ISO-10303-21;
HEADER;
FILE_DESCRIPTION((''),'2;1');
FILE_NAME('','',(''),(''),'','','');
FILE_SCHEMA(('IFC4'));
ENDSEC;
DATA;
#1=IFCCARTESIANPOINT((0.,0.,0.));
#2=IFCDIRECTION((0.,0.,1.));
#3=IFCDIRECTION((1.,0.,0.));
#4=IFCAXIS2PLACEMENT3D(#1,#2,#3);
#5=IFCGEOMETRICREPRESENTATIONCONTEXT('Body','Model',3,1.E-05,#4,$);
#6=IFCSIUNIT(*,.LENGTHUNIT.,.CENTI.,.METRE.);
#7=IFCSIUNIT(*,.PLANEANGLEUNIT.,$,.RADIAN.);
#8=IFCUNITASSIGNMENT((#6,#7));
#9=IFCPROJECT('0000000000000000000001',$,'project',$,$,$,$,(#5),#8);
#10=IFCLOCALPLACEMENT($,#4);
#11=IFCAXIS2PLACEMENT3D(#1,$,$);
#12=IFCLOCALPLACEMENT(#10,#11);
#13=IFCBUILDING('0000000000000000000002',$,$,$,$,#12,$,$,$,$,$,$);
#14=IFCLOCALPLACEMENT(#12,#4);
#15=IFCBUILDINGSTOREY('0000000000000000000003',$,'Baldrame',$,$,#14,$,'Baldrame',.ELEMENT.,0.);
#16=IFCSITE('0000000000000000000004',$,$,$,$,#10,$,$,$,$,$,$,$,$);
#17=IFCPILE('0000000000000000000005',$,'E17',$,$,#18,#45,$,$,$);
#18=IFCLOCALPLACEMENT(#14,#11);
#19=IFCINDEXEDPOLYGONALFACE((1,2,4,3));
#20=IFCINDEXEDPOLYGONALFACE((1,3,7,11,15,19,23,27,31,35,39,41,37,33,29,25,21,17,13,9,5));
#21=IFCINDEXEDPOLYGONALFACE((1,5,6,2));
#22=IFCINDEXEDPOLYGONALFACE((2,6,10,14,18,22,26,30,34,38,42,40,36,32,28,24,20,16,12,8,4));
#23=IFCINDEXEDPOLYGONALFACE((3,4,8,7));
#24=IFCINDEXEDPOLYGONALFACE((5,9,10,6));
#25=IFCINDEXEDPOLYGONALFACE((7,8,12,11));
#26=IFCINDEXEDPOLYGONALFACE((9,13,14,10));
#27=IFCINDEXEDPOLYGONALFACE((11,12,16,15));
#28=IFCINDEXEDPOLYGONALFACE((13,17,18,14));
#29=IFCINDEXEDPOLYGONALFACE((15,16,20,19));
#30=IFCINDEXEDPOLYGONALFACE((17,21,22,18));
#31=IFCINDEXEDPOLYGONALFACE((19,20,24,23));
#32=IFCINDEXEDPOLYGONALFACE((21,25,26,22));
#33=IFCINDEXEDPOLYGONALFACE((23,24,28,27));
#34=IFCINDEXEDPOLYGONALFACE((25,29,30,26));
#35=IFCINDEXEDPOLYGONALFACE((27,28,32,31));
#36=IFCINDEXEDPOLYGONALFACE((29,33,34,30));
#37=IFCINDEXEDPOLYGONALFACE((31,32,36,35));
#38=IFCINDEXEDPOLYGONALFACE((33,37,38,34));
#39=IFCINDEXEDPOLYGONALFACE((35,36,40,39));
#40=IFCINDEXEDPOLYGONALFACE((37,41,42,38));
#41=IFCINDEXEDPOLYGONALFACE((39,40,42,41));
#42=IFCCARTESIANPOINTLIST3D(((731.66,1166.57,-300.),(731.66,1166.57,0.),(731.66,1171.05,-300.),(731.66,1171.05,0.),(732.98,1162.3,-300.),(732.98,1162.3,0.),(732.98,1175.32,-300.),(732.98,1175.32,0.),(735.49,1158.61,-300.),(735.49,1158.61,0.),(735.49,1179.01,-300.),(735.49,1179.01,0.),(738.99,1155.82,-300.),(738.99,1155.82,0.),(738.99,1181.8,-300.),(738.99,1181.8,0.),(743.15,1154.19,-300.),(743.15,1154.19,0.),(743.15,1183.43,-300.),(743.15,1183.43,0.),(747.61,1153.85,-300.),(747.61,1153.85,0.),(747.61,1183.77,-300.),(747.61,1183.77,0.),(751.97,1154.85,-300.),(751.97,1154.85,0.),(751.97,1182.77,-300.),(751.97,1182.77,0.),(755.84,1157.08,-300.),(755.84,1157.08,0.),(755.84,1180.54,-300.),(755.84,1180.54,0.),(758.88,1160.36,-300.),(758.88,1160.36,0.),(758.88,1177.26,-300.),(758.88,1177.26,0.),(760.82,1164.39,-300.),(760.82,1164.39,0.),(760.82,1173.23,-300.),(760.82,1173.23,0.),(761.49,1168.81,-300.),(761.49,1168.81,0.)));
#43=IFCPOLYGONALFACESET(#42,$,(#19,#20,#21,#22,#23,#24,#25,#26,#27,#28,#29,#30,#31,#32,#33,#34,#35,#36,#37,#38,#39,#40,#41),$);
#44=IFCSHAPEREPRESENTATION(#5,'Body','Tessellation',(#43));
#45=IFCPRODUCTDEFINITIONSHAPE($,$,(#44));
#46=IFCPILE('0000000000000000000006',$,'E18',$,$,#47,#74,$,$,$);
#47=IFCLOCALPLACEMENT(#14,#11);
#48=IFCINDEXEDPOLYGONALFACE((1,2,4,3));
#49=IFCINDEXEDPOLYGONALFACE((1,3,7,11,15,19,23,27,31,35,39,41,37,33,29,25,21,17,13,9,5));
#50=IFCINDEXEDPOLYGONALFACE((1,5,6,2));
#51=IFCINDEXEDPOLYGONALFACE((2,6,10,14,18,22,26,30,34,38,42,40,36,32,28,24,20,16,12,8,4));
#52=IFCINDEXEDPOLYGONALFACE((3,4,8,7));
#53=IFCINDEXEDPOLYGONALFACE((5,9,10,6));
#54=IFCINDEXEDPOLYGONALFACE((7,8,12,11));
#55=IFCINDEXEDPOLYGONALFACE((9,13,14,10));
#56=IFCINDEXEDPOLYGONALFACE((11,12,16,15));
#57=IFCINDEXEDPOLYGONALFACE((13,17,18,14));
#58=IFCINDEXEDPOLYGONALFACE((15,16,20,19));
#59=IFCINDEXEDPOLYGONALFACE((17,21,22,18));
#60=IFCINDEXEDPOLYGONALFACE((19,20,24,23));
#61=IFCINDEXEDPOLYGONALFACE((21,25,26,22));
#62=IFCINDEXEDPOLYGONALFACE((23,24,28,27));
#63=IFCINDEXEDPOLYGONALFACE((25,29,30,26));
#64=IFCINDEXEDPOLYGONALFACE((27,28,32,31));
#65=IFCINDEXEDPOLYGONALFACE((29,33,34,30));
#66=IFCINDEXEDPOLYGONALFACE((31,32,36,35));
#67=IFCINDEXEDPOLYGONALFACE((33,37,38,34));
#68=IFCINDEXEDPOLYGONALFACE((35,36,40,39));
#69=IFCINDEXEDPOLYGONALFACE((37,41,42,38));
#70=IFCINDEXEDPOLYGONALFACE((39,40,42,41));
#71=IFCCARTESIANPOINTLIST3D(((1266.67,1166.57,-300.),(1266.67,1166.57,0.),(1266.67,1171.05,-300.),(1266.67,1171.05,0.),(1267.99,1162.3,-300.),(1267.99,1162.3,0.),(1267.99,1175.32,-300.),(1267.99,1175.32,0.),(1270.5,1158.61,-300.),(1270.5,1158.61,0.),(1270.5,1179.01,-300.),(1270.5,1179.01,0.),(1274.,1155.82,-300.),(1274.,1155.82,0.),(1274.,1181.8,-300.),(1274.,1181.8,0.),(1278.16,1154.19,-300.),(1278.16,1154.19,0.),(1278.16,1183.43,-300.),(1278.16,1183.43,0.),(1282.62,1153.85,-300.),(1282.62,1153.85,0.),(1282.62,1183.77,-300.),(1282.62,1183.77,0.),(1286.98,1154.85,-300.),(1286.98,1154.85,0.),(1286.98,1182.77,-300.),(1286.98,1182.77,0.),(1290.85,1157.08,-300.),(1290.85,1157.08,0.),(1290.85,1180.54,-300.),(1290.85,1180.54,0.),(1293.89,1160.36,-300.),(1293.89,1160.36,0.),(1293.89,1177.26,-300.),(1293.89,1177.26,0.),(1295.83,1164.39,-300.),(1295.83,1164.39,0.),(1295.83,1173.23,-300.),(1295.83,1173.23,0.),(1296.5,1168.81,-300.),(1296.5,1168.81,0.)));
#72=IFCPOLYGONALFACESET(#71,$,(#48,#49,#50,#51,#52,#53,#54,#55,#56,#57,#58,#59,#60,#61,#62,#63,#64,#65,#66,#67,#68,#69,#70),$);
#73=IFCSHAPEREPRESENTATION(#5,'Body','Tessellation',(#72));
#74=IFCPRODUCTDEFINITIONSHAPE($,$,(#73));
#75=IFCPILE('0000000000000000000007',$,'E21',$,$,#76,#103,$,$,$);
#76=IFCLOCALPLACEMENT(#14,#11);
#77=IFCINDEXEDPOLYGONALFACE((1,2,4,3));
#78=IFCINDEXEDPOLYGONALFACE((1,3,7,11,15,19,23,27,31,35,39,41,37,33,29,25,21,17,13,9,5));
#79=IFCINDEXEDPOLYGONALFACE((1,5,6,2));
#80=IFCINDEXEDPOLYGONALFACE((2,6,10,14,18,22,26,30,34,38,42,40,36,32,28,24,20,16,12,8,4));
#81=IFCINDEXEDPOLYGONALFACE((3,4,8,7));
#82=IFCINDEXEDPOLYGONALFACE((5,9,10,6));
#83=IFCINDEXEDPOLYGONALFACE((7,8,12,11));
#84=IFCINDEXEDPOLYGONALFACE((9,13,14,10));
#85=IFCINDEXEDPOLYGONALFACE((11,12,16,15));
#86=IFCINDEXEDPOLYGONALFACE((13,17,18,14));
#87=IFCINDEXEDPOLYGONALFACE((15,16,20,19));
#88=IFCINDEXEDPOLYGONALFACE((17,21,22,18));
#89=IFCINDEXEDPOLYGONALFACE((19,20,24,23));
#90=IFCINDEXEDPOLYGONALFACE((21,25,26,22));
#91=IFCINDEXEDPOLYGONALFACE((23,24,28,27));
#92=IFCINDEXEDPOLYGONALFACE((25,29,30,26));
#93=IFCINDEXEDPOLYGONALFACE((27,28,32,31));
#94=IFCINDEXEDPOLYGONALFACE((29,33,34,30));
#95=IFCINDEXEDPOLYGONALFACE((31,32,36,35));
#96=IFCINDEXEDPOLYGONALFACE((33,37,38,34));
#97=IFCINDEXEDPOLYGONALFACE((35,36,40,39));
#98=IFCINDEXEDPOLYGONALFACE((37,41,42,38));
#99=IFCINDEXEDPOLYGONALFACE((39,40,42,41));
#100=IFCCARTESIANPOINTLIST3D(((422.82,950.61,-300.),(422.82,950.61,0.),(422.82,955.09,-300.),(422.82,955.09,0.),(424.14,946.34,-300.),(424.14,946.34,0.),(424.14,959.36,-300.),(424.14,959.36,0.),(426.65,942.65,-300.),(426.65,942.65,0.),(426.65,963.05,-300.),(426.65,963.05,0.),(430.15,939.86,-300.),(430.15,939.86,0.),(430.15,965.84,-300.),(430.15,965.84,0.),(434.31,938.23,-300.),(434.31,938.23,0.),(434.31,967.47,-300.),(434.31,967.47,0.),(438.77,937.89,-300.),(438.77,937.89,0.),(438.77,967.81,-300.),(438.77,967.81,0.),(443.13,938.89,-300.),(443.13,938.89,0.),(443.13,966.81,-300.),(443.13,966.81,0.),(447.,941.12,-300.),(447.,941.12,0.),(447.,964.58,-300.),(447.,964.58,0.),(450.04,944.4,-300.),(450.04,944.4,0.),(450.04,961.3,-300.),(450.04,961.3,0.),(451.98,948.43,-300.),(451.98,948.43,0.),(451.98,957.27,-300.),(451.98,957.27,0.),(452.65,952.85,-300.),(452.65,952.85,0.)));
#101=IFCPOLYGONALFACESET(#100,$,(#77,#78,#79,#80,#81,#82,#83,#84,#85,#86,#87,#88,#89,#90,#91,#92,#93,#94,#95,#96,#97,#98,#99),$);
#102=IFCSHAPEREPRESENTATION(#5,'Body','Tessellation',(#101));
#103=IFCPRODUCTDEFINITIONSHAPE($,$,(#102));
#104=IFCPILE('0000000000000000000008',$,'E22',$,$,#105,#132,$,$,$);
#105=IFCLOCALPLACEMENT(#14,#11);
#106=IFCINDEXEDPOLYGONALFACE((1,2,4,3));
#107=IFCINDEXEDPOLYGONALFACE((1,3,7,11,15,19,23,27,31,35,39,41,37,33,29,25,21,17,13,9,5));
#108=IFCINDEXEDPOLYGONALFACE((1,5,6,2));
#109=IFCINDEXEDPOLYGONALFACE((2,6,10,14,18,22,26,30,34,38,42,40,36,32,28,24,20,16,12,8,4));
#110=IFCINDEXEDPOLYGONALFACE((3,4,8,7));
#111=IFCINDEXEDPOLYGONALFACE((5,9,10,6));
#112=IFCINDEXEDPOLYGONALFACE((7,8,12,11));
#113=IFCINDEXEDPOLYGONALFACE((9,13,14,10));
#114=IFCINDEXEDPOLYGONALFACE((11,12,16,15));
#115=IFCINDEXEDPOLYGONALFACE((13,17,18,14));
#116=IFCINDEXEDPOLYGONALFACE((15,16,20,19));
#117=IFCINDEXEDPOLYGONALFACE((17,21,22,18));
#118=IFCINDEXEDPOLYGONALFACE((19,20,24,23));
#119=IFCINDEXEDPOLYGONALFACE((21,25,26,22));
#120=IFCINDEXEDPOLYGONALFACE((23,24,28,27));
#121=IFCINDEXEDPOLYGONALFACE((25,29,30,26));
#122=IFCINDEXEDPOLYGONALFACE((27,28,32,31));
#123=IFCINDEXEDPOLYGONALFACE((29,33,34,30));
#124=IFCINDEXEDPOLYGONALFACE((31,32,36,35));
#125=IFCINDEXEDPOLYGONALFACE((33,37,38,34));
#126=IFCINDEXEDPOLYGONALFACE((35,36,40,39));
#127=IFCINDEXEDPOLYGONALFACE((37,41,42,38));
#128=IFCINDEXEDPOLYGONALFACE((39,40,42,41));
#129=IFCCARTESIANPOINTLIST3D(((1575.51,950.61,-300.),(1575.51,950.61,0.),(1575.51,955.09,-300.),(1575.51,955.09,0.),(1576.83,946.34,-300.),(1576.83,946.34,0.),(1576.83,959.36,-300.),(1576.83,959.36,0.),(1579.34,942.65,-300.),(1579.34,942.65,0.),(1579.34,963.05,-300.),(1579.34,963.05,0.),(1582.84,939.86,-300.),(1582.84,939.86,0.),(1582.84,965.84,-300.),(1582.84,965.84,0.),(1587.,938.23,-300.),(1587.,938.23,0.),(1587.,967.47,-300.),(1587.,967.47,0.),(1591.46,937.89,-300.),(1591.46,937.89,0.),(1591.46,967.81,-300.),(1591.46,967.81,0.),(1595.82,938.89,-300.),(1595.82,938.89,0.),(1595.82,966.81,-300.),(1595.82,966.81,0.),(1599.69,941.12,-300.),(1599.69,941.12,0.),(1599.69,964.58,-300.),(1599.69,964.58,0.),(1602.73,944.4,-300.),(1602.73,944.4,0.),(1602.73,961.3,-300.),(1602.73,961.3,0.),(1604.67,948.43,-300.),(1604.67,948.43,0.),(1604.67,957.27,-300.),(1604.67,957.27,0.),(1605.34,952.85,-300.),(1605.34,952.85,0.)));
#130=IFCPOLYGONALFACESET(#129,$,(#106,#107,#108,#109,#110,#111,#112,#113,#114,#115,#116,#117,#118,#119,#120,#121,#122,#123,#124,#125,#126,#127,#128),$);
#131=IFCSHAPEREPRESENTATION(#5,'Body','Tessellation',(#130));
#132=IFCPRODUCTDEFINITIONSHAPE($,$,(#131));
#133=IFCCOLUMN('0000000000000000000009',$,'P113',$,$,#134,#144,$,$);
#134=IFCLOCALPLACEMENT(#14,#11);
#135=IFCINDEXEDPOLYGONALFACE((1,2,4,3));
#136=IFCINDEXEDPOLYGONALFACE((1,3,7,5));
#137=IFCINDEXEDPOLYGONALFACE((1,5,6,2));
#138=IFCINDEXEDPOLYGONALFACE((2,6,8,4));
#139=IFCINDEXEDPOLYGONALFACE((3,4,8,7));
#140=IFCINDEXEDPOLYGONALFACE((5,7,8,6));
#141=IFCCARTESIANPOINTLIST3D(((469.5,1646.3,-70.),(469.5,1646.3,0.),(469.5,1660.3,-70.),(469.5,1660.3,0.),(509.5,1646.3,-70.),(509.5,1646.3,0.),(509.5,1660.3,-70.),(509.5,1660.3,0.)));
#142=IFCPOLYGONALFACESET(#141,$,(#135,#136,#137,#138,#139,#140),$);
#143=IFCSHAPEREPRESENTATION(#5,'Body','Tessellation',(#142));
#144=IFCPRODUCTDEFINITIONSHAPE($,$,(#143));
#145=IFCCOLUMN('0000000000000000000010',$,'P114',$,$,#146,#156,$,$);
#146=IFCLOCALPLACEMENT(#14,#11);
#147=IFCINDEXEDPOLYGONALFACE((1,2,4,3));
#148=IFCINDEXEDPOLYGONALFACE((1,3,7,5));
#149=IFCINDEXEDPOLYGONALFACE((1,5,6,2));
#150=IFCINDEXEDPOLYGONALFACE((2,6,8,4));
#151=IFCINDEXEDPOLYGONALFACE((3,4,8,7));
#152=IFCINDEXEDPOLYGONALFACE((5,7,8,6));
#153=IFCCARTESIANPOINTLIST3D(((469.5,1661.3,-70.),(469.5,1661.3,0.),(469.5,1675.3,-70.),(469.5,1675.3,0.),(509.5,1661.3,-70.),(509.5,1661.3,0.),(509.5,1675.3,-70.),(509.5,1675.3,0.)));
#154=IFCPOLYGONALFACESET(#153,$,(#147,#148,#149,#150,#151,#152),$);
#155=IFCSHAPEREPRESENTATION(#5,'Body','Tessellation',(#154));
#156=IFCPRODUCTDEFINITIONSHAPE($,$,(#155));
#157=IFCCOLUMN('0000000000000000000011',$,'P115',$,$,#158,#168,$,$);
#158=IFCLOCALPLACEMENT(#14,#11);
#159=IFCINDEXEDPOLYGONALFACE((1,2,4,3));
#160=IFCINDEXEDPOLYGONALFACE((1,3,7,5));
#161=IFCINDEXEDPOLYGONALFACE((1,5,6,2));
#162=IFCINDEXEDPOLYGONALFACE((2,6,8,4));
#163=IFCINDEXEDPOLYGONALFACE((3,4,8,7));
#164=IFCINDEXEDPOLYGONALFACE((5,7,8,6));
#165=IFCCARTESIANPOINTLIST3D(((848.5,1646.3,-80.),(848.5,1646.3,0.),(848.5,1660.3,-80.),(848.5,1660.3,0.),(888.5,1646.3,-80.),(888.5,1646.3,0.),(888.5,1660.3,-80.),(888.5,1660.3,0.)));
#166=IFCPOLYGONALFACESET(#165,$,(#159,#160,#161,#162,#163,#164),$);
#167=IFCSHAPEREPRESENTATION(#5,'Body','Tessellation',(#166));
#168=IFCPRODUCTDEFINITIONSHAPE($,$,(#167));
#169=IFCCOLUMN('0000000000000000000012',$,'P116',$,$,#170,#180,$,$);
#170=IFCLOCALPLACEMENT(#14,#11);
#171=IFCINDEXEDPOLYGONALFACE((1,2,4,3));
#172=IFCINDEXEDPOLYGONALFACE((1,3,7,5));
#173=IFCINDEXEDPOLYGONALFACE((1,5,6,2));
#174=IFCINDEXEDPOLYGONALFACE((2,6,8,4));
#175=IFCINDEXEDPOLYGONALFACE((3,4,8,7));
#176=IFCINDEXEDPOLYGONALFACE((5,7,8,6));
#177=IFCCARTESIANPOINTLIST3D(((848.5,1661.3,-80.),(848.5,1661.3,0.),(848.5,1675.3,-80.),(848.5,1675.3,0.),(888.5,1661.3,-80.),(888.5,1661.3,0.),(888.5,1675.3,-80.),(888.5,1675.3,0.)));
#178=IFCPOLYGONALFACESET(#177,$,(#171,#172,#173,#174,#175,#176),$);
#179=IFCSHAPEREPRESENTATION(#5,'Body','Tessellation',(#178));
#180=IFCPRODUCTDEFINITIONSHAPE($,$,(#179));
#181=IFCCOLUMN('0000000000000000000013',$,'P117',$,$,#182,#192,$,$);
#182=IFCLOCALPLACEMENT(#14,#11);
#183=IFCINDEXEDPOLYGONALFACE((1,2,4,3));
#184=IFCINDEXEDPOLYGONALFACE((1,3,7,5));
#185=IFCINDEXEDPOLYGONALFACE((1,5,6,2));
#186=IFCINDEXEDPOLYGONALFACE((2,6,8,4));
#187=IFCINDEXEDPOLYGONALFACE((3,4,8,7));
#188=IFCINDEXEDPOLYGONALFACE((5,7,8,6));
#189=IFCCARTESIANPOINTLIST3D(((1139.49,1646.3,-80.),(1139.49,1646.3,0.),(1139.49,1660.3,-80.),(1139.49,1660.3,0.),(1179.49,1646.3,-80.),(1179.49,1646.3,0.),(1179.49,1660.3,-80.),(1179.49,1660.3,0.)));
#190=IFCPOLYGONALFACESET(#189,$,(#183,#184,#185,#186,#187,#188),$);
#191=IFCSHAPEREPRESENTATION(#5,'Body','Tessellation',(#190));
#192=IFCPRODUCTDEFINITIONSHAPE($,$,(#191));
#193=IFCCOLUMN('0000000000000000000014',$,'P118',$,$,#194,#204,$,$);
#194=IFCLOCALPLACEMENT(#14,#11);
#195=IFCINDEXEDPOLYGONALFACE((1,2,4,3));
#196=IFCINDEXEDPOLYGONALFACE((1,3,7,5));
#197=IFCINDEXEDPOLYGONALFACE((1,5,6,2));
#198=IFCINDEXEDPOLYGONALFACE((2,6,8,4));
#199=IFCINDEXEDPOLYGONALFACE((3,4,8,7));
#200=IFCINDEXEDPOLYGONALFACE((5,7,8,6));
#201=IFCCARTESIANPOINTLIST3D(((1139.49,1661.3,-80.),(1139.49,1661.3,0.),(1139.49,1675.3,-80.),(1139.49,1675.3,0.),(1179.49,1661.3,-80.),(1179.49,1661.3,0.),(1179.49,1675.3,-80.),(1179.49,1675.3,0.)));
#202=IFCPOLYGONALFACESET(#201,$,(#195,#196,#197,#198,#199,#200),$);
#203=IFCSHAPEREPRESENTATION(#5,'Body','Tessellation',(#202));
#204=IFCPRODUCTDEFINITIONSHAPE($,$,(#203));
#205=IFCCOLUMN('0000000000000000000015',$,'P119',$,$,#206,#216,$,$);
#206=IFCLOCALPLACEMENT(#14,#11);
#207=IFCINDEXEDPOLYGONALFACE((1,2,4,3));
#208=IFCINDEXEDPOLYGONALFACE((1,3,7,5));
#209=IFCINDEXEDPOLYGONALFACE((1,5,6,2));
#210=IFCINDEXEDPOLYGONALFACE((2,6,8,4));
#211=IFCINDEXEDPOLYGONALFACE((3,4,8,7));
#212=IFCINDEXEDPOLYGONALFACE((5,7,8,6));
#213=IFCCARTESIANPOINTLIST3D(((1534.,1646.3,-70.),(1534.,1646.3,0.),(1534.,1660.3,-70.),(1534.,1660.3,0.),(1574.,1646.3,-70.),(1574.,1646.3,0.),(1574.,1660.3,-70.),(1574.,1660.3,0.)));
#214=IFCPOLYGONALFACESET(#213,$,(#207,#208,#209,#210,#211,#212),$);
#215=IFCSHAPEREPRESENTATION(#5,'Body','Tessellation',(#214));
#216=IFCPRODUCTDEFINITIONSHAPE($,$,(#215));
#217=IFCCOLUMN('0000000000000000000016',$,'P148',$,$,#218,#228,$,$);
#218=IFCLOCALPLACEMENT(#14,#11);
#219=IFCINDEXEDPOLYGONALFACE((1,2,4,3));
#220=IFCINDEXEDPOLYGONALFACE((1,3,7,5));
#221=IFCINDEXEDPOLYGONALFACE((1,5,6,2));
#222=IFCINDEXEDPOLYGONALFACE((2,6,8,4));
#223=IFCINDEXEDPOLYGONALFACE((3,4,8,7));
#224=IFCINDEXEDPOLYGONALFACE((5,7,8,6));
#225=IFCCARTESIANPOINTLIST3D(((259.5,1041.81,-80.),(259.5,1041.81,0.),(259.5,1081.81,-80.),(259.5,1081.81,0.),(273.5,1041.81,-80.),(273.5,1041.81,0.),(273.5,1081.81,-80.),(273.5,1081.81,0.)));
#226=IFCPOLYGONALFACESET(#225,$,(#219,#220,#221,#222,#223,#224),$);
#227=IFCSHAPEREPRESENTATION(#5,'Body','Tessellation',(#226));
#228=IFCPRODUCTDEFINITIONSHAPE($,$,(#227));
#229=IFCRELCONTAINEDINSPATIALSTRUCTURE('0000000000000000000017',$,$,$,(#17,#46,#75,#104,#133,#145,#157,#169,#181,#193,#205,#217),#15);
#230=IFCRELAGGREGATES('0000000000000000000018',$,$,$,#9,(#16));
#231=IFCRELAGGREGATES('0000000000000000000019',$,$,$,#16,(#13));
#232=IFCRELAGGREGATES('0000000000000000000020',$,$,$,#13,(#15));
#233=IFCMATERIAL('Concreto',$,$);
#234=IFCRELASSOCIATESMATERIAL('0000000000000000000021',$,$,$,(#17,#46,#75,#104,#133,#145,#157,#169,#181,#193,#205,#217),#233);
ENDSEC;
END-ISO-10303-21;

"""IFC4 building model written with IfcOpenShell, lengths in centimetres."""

from ifc_helpers import new_model, si_unit, frame, origin, origin_with_axes, origin_2d_with_axis, place, context, project, spatial, rectangle, circle, extrude, material, element, save


model = new_model("IFC4")

# Units and contexts
model_context = context("Model", 3, precision=1e-05, world=origin_with_axes(), identifier="Body")
ifc_project = project(units=[si_unit("LENGTHUNIT", "METRE", prefix="CENTI"), si_unit("PLANEANGLEUNIT", "RADIAN")], contexts=[model_context])

# Site, building, storey
site_placement = place(None, origin_with_axes())
site = spatial("IfcSite", under=ifc_project, at=site_placement)
building_placement = place(site_placement, origin())
building = spatial("IfcBuilding", under=site, at=building_placement)
storey_placement = place(building_placement, origin_with_axes())
storey = spatial("IfcBuildingStorey", under=building, at=storey_placement, Name="Baldrame", LongName="Baldrame", CompositionType="ELEMENT", Elevation=0.0)

# Piles
ifc_material = material(Name="Concreto")
for number, where, z_axis, x_axis, name in (
    (1, (746.49, 1168.81, 0.0), (0.0, 0.0, 1.0), (1.0, 0.0, 0.0), "E17"),
    (2, (1281.5, 1168.81, 0.0), (0.0, 0.0, 1.0), (1.0, 0.0, 0.0), "E18"),
    (3, (437.65, 952.85, 0.0), (0.0, 0.0, 1.0), (1.0, 0.0, 0.0), "E21"),
    (4, (1590.34, 952.85, 0.0), (0.0, 0.0, 1.0), (1.0, 0.0, 0.0), "E22"),
):
    element("IfcPile", number, at=place(storey_placement, frame(where, z_axis=z_axis, x_axis=x_axis)), inside=storey, material=ifc_material, Name=name, context=model_context, shape_type="SolidModel", body=[
        extrude(circle(Radius=15.0, at=origin_2d_with_axis()), frame((0.0, 0.0, -300.0), z_axis=(0.0, 0.0, 1.0), x_axis=(1.0, 0.0, 0.0)), (0.0, 0.0, 1.0), 300.0),
    ])

# Columns
for number, where, z_axis, x_axis, name in (
    (5, (489.5, 1653.3, 0.0), (0.0, 0.0, 1.0), (1.0, 0.0, 0.0), "P113"),
    (6, (489.5, 1668.3, 0.0), (0.0, 0.0, 1.0), (1.0, 0.0, 0.0), "P114"),
):
    element("IfcColumn", number, at=place(storey_placement, frame(where, z_axis=z_axis, x_axis=x_axis)), inside=storey, material=ifc_material, Name=name, context=model_context, shape_type="SolidModel", body=[
        extrude(rectangle(XDim=14.0, YDim=40.0, at=origin_2d_with_axis()), frame((0.0, 0.0, -70.0), z_axis=(0.0, 0.0, 1.0), x_axis=(0.0, 1.0, 0.0)), (0.0, 0.0, 1.0), 70.0),
    ])
for number, where, z_axis, x_axis, name in (
    (7, (868.5, 1653.3, 0.0), (0.0, 0.0, 1.0), (1.0, 0.0, 0.0), "P115"),
    (8, (868.5, 1668.3, 0.0), (0.0, 0.0, 1.0), (1.0, 0.0, 0.0), "P116"),
    (9, (1159.49, 1653.3, 0.0), (0.0, 0.0, 1.0), (1.0, 0.0, 0.0), "P117"),
    (10, (1159.49, 1668.3, 0.0), (0.0, 0.0, 1.0), (1.0, 0.0, 0.0), "P118"),
):
    element("IfcColumn", number, at=place(storey_placement, frame(where, z_axis=z_axis, x_axis=x_axis)), inside=storey, material=ifc_material, Name=name, context=model_context, shape_type="SolidModel", body=[
        extrude(rectangle(XDim=14.0, YDim=40.0, at=origin_2d_with_axis()), frame((0.0, 0.0, -80.0), z_axis=(0.0, 0.0, 1.0), x_axis=(0.0, -1.0, 0.0)), (0.0, 0.0, 1.0), 80.0),
    ])
column_1_placement = place(storey_placement, frame((1554.0, 1653.3, 0.0), z_axis=(0.0, 0.0, 1.0), x_axis=(1.0, 0.0, 0.0)))
element("IfcColumn", 11, at=column_1_placement, inside=storey, material=ifc_material, Name="P119", context=model_context, shape_type="SolidModel", body=[
    extrude(rectangle(XDim=14.0, YDim=40.0, at=origin_2d_with_axis()), frame((0.0, 0.0, -70.0), z_axis=(0.0, 0.0, 1.0), x_axis=(0.0, -1.0, 0.0)), (0.0, 0.0, 1.0), 70.0),
])
column_2_placement = place(storey_placement, frame((266.5, 1061.81, 0.0), z_axis=(0.0, 0.0, 1.0), x_axis=(1.0, 0.0, 0.0)))
element("IfcColumn", 12, at=column_2_placement, inside=storey, material=ifc_material, Name="P148", context=model_context, shape_type="SolidModel", body=[
    extrude(rectangle(XDim=14.0, YDim=40.0, at=origin_2d_with_axis()), frame((0.0, 0.0, -80.0), z_axis=(0.0, 0.0, 1.0), x_axis=(1.0, 0.0, 0.0)), (0.0, 0.0, 1.0), 80.0),
])

save(model, "model.ifc")
